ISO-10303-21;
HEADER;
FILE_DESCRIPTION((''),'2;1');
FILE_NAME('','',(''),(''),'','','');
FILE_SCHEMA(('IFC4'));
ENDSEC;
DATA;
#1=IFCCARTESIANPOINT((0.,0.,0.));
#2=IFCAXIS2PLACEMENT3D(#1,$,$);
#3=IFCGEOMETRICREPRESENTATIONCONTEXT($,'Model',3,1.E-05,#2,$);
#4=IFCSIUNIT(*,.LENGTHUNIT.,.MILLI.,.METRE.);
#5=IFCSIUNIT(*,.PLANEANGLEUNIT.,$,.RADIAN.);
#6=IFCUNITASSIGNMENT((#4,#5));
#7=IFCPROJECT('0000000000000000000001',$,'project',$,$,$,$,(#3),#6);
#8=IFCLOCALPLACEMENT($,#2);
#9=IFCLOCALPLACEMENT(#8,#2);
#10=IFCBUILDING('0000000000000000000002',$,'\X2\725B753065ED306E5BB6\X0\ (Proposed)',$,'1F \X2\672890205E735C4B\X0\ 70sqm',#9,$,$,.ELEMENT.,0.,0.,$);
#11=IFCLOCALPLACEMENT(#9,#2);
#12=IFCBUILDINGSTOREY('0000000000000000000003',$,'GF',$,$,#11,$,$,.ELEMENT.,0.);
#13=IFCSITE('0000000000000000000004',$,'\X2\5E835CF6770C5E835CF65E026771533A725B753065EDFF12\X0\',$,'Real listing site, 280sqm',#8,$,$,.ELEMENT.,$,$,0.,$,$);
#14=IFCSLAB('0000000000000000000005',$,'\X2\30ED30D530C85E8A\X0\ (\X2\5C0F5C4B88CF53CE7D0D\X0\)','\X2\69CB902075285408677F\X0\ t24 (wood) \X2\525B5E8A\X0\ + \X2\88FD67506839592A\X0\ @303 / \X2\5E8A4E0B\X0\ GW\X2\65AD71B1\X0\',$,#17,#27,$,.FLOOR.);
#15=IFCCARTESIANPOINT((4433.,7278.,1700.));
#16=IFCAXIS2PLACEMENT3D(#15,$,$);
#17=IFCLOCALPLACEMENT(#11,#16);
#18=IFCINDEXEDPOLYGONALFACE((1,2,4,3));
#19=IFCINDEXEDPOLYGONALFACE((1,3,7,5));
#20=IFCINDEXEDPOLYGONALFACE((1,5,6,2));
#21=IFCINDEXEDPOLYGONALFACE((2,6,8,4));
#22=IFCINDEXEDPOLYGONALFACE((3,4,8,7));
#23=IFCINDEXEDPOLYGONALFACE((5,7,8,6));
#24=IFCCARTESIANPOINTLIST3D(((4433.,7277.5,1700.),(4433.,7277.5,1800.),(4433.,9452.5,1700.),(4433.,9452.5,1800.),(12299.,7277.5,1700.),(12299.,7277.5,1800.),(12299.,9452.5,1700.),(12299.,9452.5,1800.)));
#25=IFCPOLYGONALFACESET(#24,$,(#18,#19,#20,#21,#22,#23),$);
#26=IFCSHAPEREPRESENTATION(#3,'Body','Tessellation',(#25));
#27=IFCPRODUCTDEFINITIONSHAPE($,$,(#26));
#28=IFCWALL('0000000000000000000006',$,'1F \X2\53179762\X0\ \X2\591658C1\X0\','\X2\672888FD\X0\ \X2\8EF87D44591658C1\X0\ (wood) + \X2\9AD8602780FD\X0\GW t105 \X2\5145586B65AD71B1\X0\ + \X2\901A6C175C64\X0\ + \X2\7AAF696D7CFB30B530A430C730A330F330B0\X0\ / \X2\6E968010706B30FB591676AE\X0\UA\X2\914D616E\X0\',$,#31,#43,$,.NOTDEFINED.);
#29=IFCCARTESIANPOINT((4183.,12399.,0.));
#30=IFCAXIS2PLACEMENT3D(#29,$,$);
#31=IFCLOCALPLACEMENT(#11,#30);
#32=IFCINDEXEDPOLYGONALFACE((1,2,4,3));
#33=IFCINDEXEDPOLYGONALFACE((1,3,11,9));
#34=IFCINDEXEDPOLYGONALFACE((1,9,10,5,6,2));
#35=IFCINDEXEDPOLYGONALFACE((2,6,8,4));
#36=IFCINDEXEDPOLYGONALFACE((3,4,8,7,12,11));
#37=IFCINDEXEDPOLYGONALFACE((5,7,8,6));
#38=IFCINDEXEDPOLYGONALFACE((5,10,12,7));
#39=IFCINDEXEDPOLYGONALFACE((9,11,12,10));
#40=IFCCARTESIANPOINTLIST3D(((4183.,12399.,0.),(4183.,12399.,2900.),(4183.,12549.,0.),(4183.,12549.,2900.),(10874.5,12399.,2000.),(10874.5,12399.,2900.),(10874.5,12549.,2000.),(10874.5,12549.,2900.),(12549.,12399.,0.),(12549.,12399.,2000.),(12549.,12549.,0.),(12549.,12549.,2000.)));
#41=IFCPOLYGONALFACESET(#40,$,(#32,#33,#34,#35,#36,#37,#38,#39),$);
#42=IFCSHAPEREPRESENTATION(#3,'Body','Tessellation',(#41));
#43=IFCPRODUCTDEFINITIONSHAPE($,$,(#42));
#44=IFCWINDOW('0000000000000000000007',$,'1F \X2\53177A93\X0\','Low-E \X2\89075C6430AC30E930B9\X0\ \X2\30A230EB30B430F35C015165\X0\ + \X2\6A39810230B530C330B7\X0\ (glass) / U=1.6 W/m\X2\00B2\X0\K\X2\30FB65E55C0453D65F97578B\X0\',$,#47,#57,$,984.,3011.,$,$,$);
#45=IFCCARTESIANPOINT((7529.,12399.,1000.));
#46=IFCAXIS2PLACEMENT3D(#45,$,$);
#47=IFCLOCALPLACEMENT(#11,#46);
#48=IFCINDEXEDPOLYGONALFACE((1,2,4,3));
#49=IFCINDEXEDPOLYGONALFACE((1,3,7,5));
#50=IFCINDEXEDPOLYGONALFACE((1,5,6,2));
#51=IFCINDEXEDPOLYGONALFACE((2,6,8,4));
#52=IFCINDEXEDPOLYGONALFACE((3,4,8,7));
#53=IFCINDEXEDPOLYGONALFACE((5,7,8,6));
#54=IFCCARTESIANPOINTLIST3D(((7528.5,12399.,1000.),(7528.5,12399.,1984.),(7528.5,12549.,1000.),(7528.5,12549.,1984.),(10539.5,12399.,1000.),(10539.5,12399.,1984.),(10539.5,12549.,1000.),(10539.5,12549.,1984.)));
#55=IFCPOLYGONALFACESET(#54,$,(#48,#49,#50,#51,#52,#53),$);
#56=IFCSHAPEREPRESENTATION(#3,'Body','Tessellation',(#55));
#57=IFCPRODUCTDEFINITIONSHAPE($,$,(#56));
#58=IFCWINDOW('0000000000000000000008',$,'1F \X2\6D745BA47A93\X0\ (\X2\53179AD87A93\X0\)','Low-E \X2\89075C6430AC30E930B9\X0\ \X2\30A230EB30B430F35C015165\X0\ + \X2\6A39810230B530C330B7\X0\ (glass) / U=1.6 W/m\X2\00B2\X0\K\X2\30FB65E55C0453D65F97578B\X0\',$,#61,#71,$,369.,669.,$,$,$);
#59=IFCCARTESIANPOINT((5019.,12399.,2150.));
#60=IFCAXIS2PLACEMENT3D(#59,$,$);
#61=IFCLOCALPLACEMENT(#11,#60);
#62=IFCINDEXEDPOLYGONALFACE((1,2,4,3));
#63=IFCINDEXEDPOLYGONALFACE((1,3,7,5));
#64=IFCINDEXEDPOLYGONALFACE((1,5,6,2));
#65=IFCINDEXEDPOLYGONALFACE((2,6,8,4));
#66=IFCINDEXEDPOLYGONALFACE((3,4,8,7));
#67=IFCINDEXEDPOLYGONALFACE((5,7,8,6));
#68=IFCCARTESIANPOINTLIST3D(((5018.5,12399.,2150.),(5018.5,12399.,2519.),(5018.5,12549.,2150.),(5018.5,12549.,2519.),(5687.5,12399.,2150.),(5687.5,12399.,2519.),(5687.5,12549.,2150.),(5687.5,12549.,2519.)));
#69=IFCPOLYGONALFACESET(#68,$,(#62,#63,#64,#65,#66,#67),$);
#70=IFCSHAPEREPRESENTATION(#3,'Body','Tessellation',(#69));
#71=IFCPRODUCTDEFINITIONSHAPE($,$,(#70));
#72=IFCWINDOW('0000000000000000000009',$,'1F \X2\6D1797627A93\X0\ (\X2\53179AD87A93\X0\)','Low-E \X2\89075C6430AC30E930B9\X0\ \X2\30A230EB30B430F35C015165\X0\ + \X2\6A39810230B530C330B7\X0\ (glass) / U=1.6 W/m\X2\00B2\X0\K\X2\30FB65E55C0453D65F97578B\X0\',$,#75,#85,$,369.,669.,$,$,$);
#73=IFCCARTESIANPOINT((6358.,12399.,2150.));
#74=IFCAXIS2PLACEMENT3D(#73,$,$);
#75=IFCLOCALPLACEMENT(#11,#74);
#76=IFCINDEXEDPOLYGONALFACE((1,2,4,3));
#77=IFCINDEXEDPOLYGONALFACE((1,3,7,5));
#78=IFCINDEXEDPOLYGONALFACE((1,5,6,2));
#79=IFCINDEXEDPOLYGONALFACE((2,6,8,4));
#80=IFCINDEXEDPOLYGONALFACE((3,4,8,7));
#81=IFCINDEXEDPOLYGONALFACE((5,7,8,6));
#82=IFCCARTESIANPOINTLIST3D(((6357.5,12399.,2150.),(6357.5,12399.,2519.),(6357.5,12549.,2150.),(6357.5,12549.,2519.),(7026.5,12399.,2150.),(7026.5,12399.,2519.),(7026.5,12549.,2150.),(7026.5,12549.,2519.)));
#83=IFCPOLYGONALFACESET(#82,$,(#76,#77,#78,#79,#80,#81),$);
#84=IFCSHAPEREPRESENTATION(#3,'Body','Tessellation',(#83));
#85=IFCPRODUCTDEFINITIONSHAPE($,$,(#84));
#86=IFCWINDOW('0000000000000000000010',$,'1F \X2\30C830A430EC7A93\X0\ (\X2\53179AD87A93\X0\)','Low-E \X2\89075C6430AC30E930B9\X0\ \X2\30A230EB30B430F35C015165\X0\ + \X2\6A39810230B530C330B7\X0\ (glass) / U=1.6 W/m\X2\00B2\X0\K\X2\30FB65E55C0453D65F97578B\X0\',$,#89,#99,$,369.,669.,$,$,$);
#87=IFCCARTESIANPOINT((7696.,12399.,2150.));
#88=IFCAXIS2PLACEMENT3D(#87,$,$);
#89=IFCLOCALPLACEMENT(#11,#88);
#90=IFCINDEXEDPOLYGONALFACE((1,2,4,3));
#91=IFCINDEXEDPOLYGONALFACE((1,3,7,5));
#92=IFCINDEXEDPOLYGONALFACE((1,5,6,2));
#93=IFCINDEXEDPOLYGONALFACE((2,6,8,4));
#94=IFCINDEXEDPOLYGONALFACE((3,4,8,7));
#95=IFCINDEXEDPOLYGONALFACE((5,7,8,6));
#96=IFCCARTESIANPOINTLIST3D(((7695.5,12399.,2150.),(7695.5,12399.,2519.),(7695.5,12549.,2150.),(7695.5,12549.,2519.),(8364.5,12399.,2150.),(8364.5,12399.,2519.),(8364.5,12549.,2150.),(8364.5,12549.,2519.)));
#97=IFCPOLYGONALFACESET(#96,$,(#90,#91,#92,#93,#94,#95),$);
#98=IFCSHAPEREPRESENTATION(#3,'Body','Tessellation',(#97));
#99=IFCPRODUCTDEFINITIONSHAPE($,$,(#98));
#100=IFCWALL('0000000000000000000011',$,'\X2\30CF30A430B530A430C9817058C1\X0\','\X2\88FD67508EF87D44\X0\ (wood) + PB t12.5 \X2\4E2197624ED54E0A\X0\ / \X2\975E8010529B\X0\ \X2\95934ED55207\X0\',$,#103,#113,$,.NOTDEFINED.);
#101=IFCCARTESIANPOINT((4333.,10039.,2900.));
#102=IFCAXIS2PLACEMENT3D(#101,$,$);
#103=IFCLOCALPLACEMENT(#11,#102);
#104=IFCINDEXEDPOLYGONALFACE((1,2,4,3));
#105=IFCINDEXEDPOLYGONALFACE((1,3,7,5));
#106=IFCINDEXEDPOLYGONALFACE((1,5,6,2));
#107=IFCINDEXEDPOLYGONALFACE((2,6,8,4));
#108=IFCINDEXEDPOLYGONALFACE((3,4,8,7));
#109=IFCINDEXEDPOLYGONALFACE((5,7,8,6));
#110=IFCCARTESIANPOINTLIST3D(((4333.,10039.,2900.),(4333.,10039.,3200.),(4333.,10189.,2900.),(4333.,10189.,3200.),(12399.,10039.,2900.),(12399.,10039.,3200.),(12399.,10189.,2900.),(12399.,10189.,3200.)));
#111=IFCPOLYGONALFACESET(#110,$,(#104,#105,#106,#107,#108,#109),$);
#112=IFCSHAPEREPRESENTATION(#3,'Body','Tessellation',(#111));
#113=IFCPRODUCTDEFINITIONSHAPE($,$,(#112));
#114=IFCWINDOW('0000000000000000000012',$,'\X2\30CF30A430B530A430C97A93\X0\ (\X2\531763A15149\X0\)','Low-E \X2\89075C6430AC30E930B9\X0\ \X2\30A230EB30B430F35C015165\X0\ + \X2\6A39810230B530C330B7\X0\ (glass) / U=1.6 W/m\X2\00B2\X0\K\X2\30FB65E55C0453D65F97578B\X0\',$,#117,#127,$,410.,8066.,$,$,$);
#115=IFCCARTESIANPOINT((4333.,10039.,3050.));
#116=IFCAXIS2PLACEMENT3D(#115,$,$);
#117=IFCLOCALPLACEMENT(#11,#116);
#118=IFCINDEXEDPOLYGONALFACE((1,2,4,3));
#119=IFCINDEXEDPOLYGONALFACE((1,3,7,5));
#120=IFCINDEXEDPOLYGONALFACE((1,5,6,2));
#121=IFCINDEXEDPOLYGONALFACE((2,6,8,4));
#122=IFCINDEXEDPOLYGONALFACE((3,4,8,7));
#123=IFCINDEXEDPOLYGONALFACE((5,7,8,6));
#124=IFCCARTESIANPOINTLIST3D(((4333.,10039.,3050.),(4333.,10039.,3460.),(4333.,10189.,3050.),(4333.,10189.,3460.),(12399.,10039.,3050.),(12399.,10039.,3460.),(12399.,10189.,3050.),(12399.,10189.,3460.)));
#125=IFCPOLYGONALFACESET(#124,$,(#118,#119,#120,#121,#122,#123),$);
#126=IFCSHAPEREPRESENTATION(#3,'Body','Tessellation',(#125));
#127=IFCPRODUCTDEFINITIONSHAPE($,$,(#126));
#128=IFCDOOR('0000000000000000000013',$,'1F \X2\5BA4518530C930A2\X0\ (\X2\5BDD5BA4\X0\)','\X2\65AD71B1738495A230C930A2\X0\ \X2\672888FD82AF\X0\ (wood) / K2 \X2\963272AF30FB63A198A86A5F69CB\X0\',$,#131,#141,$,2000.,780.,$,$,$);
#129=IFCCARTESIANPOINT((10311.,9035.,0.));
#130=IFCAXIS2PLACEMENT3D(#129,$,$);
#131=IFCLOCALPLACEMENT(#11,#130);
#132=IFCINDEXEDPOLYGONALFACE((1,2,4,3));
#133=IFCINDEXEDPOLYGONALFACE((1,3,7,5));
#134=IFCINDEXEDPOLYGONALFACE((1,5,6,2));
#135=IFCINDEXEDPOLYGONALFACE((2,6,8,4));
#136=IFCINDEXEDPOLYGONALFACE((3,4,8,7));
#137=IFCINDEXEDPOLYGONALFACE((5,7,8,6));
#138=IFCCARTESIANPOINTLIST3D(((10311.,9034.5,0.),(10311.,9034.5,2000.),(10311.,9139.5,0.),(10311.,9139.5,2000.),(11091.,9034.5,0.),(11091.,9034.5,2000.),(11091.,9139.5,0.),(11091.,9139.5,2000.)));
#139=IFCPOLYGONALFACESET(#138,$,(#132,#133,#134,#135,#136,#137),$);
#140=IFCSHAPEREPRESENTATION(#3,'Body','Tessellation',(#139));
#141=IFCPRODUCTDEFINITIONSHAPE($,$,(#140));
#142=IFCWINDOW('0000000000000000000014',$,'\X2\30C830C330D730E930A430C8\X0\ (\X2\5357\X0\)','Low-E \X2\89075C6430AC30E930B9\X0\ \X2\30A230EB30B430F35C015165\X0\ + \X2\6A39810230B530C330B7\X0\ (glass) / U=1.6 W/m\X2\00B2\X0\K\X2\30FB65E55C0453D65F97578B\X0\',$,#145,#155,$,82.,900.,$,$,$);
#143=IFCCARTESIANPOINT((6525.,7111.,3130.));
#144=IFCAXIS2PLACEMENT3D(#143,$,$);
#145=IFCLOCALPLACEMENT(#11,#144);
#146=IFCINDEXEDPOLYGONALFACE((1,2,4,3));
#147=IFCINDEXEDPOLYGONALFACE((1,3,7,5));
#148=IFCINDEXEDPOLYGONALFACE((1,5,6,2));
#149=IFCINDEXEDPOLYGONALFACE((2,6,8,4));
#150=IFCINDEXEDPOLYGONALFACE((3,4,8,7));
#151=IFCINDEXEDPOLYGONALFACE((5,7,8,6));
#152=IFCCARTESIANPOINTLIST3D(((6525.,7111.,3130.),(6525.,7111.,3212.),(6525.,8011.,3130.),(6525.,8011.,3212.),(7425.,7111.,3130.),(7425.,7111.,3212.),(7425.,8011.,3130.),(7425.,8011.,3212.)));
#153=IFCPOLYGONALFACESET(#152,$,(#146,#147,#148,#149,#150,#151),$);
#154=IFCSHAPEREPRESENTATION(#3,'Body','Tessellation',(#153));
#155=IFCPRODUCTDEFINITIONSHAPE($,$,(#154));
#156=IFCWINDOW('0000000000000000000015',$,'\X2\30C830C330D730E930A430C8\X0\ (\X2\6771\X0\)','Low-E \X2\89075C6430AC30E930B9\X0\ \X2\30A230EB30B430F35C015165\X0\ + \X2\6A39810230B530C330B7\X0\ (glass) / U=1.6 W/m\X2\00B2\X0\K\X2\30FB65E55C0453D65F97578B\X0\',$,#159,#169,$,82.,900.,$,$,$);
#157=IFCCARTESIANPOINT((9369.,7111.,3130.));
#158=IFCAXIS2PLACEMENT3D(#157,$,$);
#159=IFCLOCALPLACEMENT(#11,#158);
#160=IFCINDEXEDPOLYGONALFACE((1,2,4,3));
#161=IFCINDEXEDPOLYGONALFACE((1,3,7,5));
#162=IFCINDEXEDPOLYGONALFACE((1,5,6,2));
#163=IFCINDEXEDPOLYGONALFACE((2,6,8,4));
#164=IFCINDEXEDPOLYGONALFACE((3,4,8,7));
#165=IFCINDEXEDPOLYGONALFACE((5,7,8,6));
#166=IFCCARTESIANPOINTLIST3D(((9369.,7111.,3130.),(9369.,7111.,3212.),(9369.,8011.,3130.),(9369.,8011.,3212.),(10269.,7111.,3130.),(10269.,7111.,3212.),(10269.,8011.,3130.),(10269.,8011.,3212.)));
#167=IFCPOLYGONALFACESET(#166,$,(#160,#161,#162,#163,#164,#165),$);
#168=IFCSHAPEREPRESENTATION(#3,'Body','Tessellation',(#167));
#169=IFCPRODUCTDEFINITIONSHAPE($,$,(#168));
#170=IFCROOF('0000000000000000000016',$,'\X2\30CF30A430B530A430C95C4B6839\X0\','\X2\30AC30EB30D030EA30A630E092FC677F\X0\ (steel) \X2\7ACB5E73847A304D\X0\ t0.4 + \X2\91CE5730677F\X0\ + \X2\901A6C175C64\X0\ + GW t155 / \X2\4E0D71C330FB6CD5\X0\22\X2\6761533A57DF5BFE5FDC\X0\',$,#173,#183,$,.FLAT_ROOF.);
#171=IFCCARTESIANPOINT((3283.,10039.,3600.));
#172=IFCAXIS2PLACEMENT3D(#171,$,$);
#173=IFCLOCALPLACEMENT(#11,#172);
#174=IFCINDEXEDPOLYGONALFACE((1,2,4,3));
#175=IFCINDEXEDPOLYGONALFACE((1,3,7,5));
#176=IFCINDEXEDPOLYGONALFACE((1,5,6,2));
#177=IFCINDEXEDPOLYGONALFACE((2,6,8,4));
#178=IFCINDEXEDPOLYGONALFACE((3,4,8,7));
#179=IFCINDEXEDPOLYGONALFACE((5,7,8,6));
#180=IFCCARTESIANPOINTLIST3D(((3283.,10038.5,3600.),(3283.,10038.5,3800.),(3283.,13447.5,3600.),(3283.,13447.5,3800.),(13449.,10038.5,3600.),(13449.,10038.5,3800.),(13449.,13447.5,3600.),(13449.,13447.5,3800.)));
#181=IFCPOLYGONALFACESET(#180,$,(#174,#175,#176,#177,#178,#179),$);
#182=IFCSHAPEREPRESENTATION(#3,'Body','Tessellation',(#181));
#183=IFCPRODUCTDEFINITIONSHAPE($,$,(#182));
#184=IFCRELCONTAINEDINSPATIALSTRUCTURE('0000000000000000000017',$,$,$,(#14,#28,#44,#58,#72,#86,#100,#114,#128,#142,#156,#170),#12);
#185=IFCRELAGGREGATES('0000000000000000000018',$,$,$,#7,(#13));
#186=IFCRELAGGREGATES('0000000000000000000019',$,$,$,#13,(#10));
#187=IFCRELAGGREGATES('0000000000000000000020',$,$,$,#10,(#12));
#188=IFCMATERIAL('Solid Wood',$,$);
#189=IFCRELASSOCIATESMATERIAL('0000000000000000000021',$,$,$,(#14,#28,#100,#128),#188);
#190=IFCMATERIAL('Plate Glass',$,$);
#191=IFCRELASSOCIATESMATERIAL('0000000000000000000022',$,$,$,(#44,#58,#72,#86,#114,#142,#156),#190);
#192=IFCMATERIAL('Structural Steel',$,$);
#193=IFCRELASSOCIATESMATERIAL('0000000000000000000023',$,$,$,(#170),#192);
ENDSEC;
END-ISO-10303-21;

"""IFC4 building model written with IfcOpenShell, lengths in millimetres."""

from ifc_helpers import new_model, si_unit, frame, frame_2d, origin, place, context, project, spatial, rectangle, extrude, material, element, fill, save


model = new_model("IFC4")

# Units and contexts
model_context = context("Model", 3, precision=1e-05, world=origin())
ifc_project = project(units=[si_unit("LENGTHUNIT", "METRE", prefix="MILLI"), si_unit("PLANEANGLEUNIT", "RADIAN")], contexts=[model_context])

# Site, building, storey
site_placement = place(None, origin())
site = spatial("IfcSite", under=ifc_project, at=site_placement, Name="広島県広島市東区牛田旭２", ObjectType="Real listing site, 280sqm", CompositionType="ELEMENT", RefElevation=0.0)
building_placement = place(site_placement, origin())
building = spatial("IfcBuilding", under=site, at=building_placement, Name="牛田旭の家 (Proposed)", ObjectType="1F 木造平屋 70sqm", CompositionType="ELEMENT", ElevationOfRefHeight=0.0, ElevationOfTerrain=0.0)
storey_placement = place(building_placement, origin())
storey = spatial("IfcBuildingStorey", under=building, at=storey_placement, Name="GF", CompositionType="ELEMENT", Elevation=0.0)

# Slab
ifc_material_1 = material(Name="Solid Wood")
slab_placement = place(storey_placement, frame((4433.0, 7278.0, 1700.0)))
element("IfcSlab", 1, at=slab_placement, inside=storey, material=ifc_material_1, Name="ロフト床 (小屋裏収納)", Description="構造用合板 t24 (wood) 剛床 + 製材根太 @303 / 床下 GW断熱", PredefinedType="FLOOR", context=model_context, shape_type="SweptSolid", body=[
    extrude(rectangle(XDim=7866.0, YDim=2175.0, at=frame_2d((3933.0, 1087.0))), frame((4433.0, 7278.0, 1700.0)), (0.0, 0.0, 1.0), 100.0),
])

# Wall, openings, windows
wall_1_placement = place(storey_placement, frame((4183.0, 12399.0, 0.0)))
wall_1 = element("IfcWall", 2, at=wall_1_placement, inside=storey, material=ifc_material_1, Name="1F 北面 外壁", Description="木製 軸組外壁 (wood) + 高性能GW t105 充填断熱 + 通気層 + 窯業系サイディング / 準耐火・外皮UA配慮", PredefinedType="NOTDEFINED", context=model_context, shape_type="SweptSolid", body=[
    extrude(rectangle(XDim=8366.0, YDim=150.0, at=frame_2d((4183.0, 75.0))), frame((4183.0, 12399.0, 0.0)), (0.0, 0.0, 1.0), 2900.0),
])
opening_1_placement = place(storey_placement, frame((7529.0, 12399.0, 1000.0)))
opening_1 = element("IfcOpeningElement", 3, at=opening_1_placement, cuts=wall_1, PredefinedType="NOTDEFINED", context=model_context, shape_type="SweptSolid", body=[
    extrude(rectangle(XDim=3011.0, YDim=150.0, at=frame_2d((1505.0, 75.0))), frame((7529.0, 12399.0, 1000.0)), (0.0, 0.0, 1.0), 984.0),
])
opening_2_placement = place(storey_placement, frame((5019.0, 12399.0, 2150.0)))
opening_2 = element("IfcOpeningElement", 4, at=opening_2_placement, cuts=wall_1, PredefinedType="NOTDEFINED", context=model_context, shape_type="SweptSolid", body=[
    extrude(rectangle(XDim=669.0, YDim=150.0, at=frame_2d((334.0, 75.0))), frame((5019.0, 12399.0, 2150.0)), (0.0, 0.0, 1.0), 369.0),
])
opening_3_placement = place(storey_placement, frame((6358.0, 12399.0, 2150.0)))
opening_3 = element("IfcOpeningElement", 5, at=opening_3_placement, cuts=wall_1, PredefinedType="NOTDEFINED", context=model_context, shape_type="SweptSolid", body=[
    extrude(rectangle(XDim=669.0, YDim=150.0, at=frame_2d((334.0, 75.0))), frame((6358.0, 12399.0, 2150.0)), (0.0, 0.0, 1.0), 369.0),
])
opening_4_placement = place(storey_placement, frame((7696.0, 12399.0, 2150.0)))
opening_4 = element("IfcOpeningElement", 6, at=opening_4_placement, cuts=wall_1, PredefinedType="NOTDEFINED", context=model_context, shape_type="SweptSolid", body=[
    extrude(rectangle(XDim=669.0, YDim=150.0, at=frame_2d((334.0, 75.0))), frame((7696.0, 12399.0, 2150.0)), (0.0, 0.0, 1.0), 369.0),
])
ifc_material_2 = material(Name="Plate Glass")
window_1_placement = place(storey_placement, frame((7529.0, 12399.0, 1000.0)))
window_1 = element("IfcWindow", 7, at=window_1_placement, inside=storey, material=ifc_material_2, Name="1F 北窓", Description="Low-E 複層ガラス アルゴン封入 + 樹脂サッシ (glass) / U=1.6 W/m²K・日射取得型", OverallHeight=984.0, OverallWidth=3011.0, context=model_context, shape_type="SweptSolid", body=[
    extrude(rectangle(XDim=3011.0, YDim=150.0, at=frame_2d((1505.0, 75.0))), frame((7529.0, 12399.0, 1000.0)), (0.0, 0.0, 1.0), 984.0),
])
fill(opening_1, window_1)
window_2_placement = place(storey_placement, frame((5019.0, 12399.0, 2150.0)))
window_2 = element("IfcWindow", 8, at=window_2_placement, inside=storey, material=ifc_material_2, Name="1F 浴室窓 (北高窓)", Description="Low-E 複層ガラス アルゴン封入 + 樹脂サッシ (glass) / U=1.6 W/m²K・日射取得型", OverallHeight=369.0, OverallWidth=669.0, context=model_context, shape_type="SweptSolid", body=[
    extrude(rectangle(XDim=669.0, YDim=150.0, at=frame_2d((334.0, 75.0))), frame((5019.0, 12399.0, 2150.0)), (0.0, 0.0, 1.0), 369.0),
])
fill(opening_2, window_2)
window_3_placement = place(storey_placement, frame((6358.0, 12399.0, 2150.0)))
window_3 = element("IfcWindow", 9, at=window_3_placement, inside=storey, material=ifc_material_2, Name="1F 洗面窓 (北高窓)", Description="Low-E 複層ガラス アルゴン封入 + 樹脂サッシ (glass) / U=1.6 W/m²K・日射取得型", OverallHeight=369.0, OverallWidth=669.0, context=model_context, shape_type="SweptSolid", body=[
    extrude(rectangle(XDim=669.0, YDim=150.0, at=frame_2d((334.0, 75.0))), frame((6358.0, 12399.0, 2150.0)), (0.0, 0.0, 1.0), 369.0),
])
fill(opening_3, window_3)
window_4_placement = place(storey_placement, frame((7696.0, 12399.0, 2150.0)))
window_4 = element("IfcWindow", 10, at=window_4_placement, inside=storey, material=ifc_material_2, Name="1F トイレ窓 (北高窓)", Description="Low-E 複層ガラス アルゴン封入 + 樹脂サッシ (glass) / U=1.6 W/m²K・日射取得型", OverallHeight=369.0, OverallWidth=669.0, context=model_context, shape_type="SweptSolid", body=[
    extrude(rectangle(XDim=669.0, YDim=150.0, at=frame_2d((334.0, 75.0))), frame((7696.0, 12399.0, 2150.0)), (0.0, 0.0, 1.0), 369.0),
])
fill(opening_4, window_4)

# Wall, opening, window
wall_2_placement = place(storey_placement, frame((4333.0, 10039.0, 2900.0)))
wall_2 = element("IfcWall", 11, at=wall_2_placement, inside=storey, material=ifc_material_1, Name="ハイサイド腰壁", Description="製材軸組 (wood) + PB t12.5 両面仕上 / 非耐力 間仕切", PredefinedType="NOTDEFINED", context=model_context, shape_type="SweptSolid", body=[
    extrude(rectangle(XDim=8066.0, YDim=150.0, at=frame_2d((4033.0, 75.0))), frame((4333.0, 10039.0, 2900.0)), (0.0, 0.0, 1.0), 700.0),
])
opening_5_placement = place(storey_placement, frame((4333.0, 10039.0, 3050.0)))
opening_5 = element("IfcOpeningElement", 12, at=opening_5_placement, cuts=wall_2, PredefinedType="NOTDEFINED", context=model_context, shape_type="SweptSolid", body=[
    extrude(rectangle(XDim=8066.0, YDim=150.0, at=frame_2d((4033.0, 75.0))), frame((4333.0, 10039.0, 3050.0)), (0.0, 0.0, 1.0), 410.0),
])
window_5_placement = place(storey_placement, frame((4333.0, 10039.0, 3050.0)))
window_5 = element("IfcWindow", 13, at=window_5_placement, inside=storey, material=ifc_material_2, Name="ハイサイド窓 (北採光)", Description="Low-E 複層ガラス アルゴン封入 + 樹脂サッシ (glass) / U=1.6 W/m²K・日射取得型", OverallHeight=410.0, OverallWidth=8066.0, context=model_context, shape_type="SweptSolid", body=[
    extrude(rectangle(XDim=8066.0, YDim=150.0, at=frame_2d((4033.0, 75.0))), frame((4333.0, 10039.0, 3050.0)), (0.0, 0.0, 1.0), 410.0),
])
fill(opening_5, window_5)

# Door
door_1_placement = place(storey_placement, frame((10311.0, 9035.0, 0.0)))
element("IfcDoor", 14, at=door_1_placement, inside=storey, material=ifc_material_1, Name="1F 室内ドア (寝室)", Description="断熱玄関ドア 木製芯 (wood) / K2 防犯・採風機構", OverallHeight=2000.0, OverallWidth=780.0, context=model_context, shape_type="SweptSolid", body=[
    extrude(rectangle(XDim=780.0, YDim=105.0, at=frame_2d((390.0, 52.0))), frame((10311.0, 9035.0, 0.0)), (0.0, 0.0, 1.0), 2000.0),
])

# Windows
window_6_placement = place(storey_placement, frame((6525.0, 7111.0, 3130.0)))
element("IfcWindow", 15, at=window_6_placement, inside=storey, material=ifc_material_2, Name="トップライト (南)", Description="Low-E 複層ガラス アルゴン封入 + 樹脂サッシ (glass) / U=1.6 W/m²K・日射取得型", OverallHeight=82.0, OverallWidth=900.0, context=model_context, shape_type="SweptSolid", body=[
    extrude(rectangle(XDim=900.0, YDim=900.0, at=frame_2d((450.0, 450.0))), frame((6525.0, 7111.0, 3130.0)), (0.0, 0.0, 1.0), 82.0),
])
window_7_placement = place(storey_placement, frame((9369.0, 7111.0, 3130.0)))
element("IfcWindow", 16, at=window_7_placement, inside=storey, material=ifc_material_2, Name="トップライト (東)", Description="Low-E 複層ガラス アルゴン封入 + 樹脂サッシ (glass) / U=1.6 W/m²K・日射取得型", OverallHeight=82.0, OverallWidth=900.0, context=model_context, shape_type="SweptSolid", body=[
    extrude(rectangle(XDim=900.0, YDim=900.0, at=frame_2d((450.0, 450.0))), frame((9369.0, 7111.0, 3130.0)), (0.0, 0.0, 1.0), 82.0),
])

# Roof
ifc_material_3 = material(Name="Structural Steel")
roof_placement = place(storey_placement, frame((3283.0, 10039.0, 3600.0)))
element("IfcRoof", 17, at=roof_placement, inside=storey, material=ifc_material_3, Name="ハイサイド屋根", Description="ガルバリウム鋼板 (steel) 立平葺き t0.4 + 野地板 + 通気層 + GW t155 / 不燃・法22条区域対応", PredefinedType="FLAT_ROOF", context=model_context, shape_type="SweptSolid", body=[
    extrude(rectangle(XDim=10166.0, YDim=3409.0, at=frame_2d((5083.0, 1704.0))), frame((3283.0, 10039.0, 3600.0)), (0.0, 0.0, 1.0), 200.0),
])

save(model, "model.ifc")
